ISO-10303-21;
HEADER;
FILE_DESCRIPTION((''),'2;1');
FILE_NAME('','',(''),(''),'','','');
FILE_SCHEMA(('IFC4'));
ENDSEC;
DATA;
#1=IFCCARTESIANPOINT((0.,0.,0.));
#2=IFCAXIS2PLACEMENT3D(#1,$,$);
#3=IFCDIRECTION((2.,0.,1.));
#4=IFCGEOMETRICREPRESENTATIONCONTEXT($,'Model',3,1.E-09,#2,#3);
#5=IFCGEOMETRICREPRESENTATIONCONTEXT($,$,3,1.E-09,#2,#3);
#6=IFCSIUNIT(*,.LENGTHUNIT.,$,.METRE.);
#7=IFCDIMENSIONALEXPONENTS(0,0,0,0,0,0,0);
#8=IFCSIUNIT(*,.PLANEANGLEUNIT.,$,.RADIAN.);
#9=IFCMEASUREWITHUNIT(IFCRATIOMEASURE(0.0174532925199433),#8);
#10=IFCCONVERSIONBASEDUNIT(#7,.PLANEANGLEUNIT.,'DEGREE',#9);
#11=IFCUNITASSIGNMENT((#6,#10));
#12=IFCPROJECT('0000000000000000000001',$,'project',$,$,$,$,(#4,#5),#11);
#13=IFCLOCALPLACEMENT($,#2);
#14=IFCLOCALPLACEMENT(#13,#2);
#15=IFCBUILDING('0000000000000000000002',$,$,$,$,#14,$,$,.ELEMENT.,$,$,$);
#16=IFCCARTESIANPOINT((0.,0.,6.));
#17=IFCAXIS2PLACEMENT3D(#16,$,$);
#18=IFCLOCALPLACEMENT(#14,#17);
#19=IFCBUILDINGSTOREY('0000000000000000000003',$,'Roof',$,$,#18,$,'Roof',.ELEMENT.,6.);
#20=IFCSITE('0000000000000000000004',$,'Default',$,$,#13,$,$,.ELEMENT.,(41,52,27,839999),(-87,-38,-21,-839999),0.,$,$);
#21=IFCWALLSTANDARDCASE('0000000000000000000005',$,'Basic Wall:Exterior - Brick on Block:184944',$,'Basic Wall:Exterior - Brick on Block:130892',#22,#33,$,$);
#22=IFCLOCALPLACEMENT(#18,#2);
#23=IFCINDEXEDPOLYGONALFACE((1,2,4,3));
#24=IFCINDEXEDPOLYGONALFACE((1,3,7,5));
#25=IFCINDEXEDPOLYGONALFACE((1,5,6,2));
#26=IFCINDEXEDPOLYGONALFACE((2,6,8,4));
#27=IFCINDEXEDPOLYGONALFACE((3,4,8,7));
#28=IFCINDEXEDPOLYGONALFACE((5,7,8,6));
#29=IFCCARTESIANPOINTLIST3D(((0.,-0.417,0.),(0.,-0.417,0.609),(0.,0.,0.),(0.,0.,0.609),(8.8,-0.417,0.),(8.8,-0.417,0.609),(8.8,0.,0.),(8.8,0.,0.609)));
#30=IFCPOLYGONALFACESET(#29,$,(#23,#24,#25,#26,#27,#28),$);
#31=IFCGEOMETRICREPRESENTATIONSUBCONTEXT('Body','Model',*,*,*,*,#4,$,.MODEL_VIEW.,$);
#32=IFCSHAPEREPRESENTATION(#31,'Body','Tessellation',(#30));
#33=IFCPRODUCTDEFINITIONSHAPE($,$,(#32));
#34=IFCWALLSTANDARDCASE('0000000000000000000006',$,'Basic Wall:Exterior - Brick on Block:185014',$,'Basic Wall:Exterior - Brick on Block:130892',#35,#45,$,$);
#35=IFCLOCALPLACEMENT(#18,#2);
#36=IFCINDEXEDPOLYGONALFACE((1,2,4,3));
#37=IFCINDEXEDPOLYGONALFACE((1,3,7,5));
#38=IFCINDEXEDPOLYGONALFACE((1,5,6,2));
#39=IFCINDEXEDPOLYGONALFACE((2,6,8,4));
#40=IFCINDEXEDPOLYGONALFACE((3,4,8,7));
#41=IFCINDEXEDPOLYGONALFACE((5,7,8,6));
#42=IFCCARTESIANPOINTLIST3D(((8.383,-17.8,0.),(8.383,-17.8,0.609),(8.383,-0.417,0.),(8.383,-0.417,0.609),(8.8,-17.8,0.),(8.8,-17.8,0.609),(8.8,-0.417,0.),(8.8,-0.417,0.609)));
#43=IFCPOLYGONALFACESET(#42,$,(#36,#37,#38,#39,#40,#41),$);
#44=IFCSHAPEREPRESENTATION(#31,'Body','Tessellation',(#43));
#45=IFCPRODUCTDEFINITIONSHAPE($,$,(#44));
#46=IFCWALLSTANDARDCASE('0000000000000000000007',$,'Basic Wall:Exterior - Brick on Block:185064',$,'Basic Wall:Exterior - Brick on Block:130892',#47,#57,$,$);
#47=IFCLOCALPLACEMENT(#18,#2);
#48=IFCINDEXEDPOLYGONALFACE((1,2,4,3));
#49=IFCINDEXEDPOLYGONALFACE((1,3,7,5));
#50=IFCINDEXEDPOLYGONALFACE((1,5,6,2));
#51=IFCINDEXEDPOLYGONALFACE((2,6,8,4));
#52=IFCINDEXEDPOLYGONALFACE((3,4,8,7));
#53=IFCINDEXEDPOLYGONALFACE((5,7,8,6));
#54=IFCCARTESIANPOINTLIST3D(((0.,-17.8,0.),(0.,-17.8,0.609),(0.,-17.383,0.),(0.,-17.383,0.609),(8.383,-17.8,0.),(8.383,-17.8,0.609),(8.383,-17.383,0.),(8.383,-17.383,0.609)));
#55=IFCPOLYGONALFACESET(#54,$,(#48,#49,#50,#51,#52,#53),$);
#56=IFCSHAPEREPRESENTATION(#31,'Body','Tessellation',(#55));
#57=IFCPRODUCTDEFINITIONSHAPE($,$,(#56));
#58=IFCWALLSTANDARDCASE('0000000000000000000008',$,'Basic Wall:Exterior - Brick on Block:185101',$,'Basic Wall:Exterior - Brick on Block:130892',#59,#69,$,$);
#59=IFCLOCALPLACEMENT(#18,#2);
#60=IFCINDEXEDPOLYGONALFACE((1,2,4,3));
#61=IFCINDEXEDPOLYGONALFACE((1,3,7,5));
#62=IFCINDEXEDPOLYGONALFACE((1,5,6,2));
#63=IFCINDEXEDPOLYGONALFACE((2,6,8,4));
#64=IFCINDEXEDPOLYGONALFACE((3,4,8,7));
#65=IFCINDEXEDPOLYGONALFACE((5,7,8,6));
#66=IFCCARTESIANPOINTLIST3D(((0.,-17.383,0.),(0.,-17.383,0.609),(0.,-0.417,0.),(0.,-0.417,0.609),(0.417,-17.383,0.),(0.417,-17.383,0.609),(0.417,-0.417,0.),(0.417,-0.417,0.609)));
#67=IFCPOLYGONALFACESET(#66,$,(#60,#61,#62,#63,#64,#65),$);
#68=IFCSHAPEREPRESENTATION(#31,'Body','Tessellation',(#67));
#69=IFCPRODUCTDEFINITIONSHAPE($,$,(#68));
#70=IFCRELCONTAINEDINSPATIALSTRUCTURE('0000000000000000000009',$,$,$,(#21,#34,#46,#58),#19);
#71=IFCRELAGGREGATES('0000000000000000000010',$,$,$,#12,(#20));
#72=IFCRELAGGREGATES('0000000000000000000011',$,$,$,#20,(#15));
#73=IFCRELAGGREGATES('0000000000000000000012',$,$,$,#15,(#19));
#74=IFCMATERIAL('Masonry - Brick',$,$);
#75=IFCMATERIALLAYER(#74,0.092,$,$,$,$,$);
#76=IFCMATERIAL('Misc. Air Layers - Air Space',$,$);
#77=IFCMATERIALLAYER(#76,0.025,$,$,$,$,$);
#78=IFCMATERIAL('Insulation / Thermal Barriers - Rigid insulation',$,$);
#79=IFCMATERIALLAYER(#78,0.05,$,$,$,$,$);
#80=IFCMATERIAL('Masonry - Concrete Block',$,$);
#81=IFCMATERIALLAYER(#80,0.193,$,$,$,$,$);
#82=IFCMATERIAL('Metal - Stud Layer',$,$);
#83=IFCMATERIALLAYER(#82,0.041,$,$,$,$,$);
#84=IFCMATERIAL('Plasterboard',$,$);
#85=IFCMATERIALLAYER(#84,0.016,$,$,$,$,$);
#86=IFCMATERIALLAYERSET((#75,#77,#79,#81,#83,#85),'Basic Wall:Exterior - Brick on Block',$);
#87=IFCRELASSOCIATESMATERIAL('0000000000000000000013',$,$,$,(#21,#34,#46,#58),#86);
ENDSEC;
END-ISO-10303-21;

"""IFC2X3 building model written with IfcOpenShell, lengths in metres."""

from ifc_helpers import new_model, entity, si_unit, converted_unit, direction, frame, frame_2d, origin, place, context, subcontext, project, spatial, rectangle, extrude, material, layer, layer_set, layer_usage, element, save


model = new_model("IFC2X3")

# Units and contexts
model_context = context("Model", 3, precision=1e-09, world=origin(), true_north=direction((2.0, 0.0, 1.0)))
context_of_model = context(None, 3, precision=1e-09, world=origin(), true_north=direction((2.0, 0.0, 1.0)))
body_context = subcontext(model_context, "Body", "Model", "MODEL_VIEW")
ifc_project = project(units=[si_unit("LENGTHUNIT", "METRE"), converted_unit("PLANEANGLEUNIT", "DEGREE", entity("IfcRatioMeasure", 0.0174532925199433), si_unit("PLANEANGLEUNIT", "RADIAN"), dimensions=[0, 0, 0, 0, 0, 0, 0])], contexts=[model_context, context_of_model])

# Site, building, storey
site_placement = place(None, origin())
site = spatial("IfcSite", under=ifc_project, at=site_placement, Name="Default", CompositionType="ELEMENT", RefLatitude=(41, 52, 27, 839999), RefLongitude=(-87, -38, -21, -839999), RefElevation=0.0)
building_placement = place(site_placement, origin())
building = spatial("IfcBuilding", under=site, at=building_placement, CompositionType="ELEMENT")
storey_placement = place(building_placement, frame((0.0, 0.0, 6.0)))
storey = spatial("IfcBuildingStorey", under=building, at=storey_placement, Name="Roof", LongName="Roof", CompositionType="ELEMENT", Elevation=6.0)

# Walls
ifc_material_1 = material(Name="Masonry - Brick")
ifc_layer_1 = layer(ifc_material_1, 0.092)
ifc_material_2 = material(Name="Misc. Air Layers - Air Space")
ifc_layer_2 = layer(ifc_material_2, 0.025)
ifc_material_3 = material(Name="Insulation / Thermal Barriers - Rigid insulation")
ifc_layer_3 = layer(ifc_material_3, 0.05)
ifc_material_4 = material(Name="Masonry - Concrete Block")
ifc_layer_4 = layer(ifc_material_4, 0.193)
ifc_material_5 = material(Name="Metal - Stud Layer")
ifc_layer_5 = layer(ifc_material_5, 0.041)
ifc_material_6 = material(Name="Plasterboard")
ifc_layer_6 = layer(ifc_material_6, 0.016)
ifc_layer_set = layer_set([ifc_layer_1, ifc_layer_2, ifc_layer_3, ifc_layer_4, ifc_layer_5, ifc_layer_6], Name="Basic Wall:Exterior - Brick on Block")
ifc_layer_usage_1 = layer_usage(ifc_layer_set, "AXIS2", "NEGATIVE", 0.2085)
wall_1_placement = place(storey_placement, frame((0.0, -0.2085, 0.0)))
element("IfcWallStandardCase", 1, at=wall_1_placement, inside=storey, material=ifc_layer_usage_1, Name="Basic Wall:Exterior - Brick on Block:184944", ObjectType="Basic Wall:Exterior - Brick on Block:130892", context=body_context, shape_type="SweptSolid", body=[
    extrude(rectangle(XDim=8.8, YDim=0.417, at=frame_2d((4.4, 0.0), x_axis=(-1.0, 0.0))), origin(), (0.0, 0.0, 1.0), 0.609),
])
ifc_layer_usage_2 = layer_usage(ifc_layer_set, "AXIS2", "NEGATIVE", 0.2085)
wall_2_placement = place(storey_placement, frame((8.5915, -0.417, 0.0), z_axis=(0.0, 0.0, 1.0), x_axis=(0.0, -1.0, 0.0)))
element("IfcWallStandardCase", 2, at=wall_2_placement, inside=storey, material=ifc_layer_usage_2, Name="Basic Wall:Exterior - Brick on Block:185014", ObjectType="Basic Wall:Exterior - Brick on Block:130892", context=body_context, shape_type="SweptSolid", body=[
    extrude(rectangle(XDim=17.383, YDim=0.417, at=frame_2d((8.6915, 0.0), x_axis=(-1.0, 0.0))), origin(), (0.0, 0.0, 1.0), 0.609),
])
ifc_layer_usage_3 = layer_usage(ifc_layer_set, "AXIS2", "NEGATIVE", 0.2085)
wall_3_placement = place(storey_placement, frame((8.383, -17.5915, 0.0), z_axis=(0.0, 0.0, 1.0), x_axis=(-1.0, 0.0, 0.0)))
element("IfcWallStandardCase", 3, at=wall_3_placement, inside=storey, material=ifc_layer_usage_3, Name="Basic Wall:Exterior - Brick on Block:185064", ObjectType="Basic Wall:Exterior - Brick on Block:130892", context=body_context, shape_type="SweptSolid", body=[
    extrude(rectangle(XDim=8.383, YDim=0.417, at=frame_2d((4.1915, 0.0), x_axis=(-1.0, 0.0))), origin(), (0.0, 0.0, 1.0), 0.609),
])
ifc_layer_usage_4 = layer_usage(ifc_layer_set, "AXIS2", "NEGATIVE", 0.2085)
wall_4_placement = place(storey_placement, frame((0.2085, -17.383, 0.0), z_axis=(0.0, 0.0, 1.0), x_axis=(0.0, 1.0, 0.0)))
element("IfcWallStandardCase", 4, at=wall_4_placement, inside=storey, material=ifc_layer_usage_4, Name="Basic Wall:Exterior - Brick on Block:185101", ObjectType="Basic Wall:Exterior - Brick on Block:130892", context=body_context, shape_type="SweptSolid", body=[
    extrude(rectangle(XDim=16.966, YDim=0.417, at=frame_2d((8.483, 0.0), x_axis=(-1.0, 0.0))), origin(), (0.0, 0.0, 1.0), 0.609),
])

save(model, "model.ifc")
